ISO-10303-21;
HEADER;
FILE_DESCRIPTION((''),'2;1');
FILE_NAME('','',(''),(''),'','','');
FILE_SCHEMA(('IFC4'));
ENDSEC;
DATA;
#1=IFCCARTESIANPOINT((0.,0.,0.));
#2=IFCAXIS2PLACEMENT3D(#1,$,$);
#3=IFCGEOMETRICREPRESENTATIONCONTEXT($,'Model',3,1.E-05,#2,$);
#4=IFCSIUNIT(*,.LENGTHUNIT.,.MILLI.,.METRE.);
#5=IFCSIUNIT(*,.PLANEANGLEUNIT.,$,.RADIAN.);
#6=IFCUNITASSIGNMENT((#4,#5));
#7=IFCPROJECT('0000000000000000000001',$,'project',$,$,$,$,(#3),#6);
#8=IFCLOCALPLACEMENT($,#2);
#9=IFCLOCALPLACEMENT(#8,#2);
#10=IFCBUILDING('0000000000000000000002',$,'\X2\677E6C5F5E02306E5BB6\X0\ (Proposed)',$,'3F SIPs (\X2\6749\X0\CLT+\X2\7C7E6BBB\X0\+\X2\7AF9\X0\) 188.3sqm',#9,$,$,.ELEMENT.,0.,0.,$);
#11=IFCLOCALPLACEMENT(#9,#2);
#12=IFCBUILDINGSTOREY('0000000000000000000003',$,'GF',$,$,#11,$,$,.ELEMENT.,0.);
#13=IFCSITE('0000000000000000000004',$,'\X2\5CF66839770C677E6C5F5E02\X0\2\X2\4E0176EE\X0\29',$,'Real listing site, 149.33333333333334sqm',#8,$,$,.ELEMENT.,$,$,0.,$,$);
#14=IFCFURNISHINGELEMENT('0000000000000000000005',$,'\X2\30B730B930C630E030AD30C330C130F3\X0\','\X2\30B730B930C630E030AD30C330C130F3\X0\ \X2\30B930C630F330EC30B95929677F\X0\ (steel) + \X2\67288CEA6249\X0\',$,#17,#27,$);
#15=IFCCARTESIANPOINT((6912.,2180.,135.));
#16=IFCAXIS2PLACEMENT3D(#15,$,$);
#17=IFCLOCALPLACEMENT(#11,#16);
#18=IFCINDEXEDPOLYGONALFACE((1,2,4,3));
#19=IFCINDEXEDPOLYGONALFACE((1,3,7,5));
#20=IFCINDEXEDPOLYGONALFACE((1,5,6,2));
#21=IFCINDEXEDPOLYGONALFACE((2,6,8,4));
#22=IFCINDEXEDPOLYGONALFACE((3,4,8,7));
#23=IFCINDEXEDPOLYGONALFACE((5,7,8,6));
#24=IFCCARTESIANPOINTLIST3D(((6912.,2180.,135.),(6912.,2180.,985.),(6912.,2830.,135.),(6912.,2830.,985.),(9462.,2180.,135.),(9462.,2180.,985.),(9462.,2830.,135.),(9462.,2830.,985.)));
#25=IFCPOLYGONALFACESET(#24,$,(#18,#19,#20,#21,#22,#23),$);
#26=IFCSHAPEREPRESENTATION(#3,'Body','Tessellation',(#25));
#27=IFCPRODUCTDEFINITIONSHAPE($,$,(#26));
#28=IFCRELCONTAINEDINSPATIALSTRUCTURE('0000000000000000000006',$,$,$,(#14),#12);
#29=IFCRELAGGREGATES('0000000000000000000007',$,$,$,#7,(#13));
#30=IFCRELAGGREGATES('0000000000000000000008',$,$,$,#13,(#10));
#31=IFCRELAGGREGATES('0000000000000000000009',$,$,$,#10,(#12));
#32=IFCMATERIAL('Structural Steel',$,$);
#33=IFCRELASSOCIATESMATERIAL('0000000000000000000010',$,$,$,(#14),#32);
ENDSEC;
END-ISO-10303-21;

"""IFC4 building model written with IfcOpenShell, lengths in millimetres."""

from ifc_helpers import new_model, si_unit, frame, frame_2d, origin, place, context, project, spatial, rectangle, extrude, material, element, save


model = new_model("IFC4")

# Units and contexts
model_context = context("Model", 3, precision=1e-05, world=origin())
ifc_project = project(units=[si_unit("LENGTHUNIT", "METRE", prefix="MILLI"), si_unit("PLANEANGLEUNIT", "RADIAN")], contexts=[model_context])

# Site, building, storey
site_placement = place(None, origin())
site = spatial("IfcSite", under=ifc_project, at=site_placement, Name="島根県松江市2丁目29", ObjectType="Real listing site, 149.33333333333334sqm", CompositionType="ELEMENT", RefElevation=0.0)
building_placement = place(site_placement, origin())
building = spatial("IfcBuilding", under=site, at=building_placement, Name="松江市の家 (Proposed)", ObjectType="3F SIPs (杉CLT+籾殻+竹) 188.3sqm", CompositionType="ELEMENT", ElevationOfRefHeight=0.0, ElevationOfTerrain=0.0)
storey_placement = place(building_placement, origin())
storey = spatial("IfcBuildingStorey", under=building, at=storey_placement, Name="GF", CompositionType="ELEMENT", Elevation=0.0)

# Furnishing element
ifc_material_1 = material(Name="Structural Steel")
furnishing_1_placement = place(storey_placement, frame((6912.0, 2180.0, 135.0)))
element("IfcFurnishingElement", 1, at=furnishing_1_placement, inside=storey, material=ifc_material_1, Name="システムキッチン", Description="システムキッチン ステンレス天板 (steel) + 木質扉", context=model_context, shape_type="SweptSolid", body=[
    extrude(rectangle(XDim=2550.0, YDim=650.0, at=frame_2d((1275.0, 325.0))), frame((6912.0, 2180.0, 135.0)), (0.0, 0.0, 1.0), 850.0),
])

save(model, "model.ifc")
